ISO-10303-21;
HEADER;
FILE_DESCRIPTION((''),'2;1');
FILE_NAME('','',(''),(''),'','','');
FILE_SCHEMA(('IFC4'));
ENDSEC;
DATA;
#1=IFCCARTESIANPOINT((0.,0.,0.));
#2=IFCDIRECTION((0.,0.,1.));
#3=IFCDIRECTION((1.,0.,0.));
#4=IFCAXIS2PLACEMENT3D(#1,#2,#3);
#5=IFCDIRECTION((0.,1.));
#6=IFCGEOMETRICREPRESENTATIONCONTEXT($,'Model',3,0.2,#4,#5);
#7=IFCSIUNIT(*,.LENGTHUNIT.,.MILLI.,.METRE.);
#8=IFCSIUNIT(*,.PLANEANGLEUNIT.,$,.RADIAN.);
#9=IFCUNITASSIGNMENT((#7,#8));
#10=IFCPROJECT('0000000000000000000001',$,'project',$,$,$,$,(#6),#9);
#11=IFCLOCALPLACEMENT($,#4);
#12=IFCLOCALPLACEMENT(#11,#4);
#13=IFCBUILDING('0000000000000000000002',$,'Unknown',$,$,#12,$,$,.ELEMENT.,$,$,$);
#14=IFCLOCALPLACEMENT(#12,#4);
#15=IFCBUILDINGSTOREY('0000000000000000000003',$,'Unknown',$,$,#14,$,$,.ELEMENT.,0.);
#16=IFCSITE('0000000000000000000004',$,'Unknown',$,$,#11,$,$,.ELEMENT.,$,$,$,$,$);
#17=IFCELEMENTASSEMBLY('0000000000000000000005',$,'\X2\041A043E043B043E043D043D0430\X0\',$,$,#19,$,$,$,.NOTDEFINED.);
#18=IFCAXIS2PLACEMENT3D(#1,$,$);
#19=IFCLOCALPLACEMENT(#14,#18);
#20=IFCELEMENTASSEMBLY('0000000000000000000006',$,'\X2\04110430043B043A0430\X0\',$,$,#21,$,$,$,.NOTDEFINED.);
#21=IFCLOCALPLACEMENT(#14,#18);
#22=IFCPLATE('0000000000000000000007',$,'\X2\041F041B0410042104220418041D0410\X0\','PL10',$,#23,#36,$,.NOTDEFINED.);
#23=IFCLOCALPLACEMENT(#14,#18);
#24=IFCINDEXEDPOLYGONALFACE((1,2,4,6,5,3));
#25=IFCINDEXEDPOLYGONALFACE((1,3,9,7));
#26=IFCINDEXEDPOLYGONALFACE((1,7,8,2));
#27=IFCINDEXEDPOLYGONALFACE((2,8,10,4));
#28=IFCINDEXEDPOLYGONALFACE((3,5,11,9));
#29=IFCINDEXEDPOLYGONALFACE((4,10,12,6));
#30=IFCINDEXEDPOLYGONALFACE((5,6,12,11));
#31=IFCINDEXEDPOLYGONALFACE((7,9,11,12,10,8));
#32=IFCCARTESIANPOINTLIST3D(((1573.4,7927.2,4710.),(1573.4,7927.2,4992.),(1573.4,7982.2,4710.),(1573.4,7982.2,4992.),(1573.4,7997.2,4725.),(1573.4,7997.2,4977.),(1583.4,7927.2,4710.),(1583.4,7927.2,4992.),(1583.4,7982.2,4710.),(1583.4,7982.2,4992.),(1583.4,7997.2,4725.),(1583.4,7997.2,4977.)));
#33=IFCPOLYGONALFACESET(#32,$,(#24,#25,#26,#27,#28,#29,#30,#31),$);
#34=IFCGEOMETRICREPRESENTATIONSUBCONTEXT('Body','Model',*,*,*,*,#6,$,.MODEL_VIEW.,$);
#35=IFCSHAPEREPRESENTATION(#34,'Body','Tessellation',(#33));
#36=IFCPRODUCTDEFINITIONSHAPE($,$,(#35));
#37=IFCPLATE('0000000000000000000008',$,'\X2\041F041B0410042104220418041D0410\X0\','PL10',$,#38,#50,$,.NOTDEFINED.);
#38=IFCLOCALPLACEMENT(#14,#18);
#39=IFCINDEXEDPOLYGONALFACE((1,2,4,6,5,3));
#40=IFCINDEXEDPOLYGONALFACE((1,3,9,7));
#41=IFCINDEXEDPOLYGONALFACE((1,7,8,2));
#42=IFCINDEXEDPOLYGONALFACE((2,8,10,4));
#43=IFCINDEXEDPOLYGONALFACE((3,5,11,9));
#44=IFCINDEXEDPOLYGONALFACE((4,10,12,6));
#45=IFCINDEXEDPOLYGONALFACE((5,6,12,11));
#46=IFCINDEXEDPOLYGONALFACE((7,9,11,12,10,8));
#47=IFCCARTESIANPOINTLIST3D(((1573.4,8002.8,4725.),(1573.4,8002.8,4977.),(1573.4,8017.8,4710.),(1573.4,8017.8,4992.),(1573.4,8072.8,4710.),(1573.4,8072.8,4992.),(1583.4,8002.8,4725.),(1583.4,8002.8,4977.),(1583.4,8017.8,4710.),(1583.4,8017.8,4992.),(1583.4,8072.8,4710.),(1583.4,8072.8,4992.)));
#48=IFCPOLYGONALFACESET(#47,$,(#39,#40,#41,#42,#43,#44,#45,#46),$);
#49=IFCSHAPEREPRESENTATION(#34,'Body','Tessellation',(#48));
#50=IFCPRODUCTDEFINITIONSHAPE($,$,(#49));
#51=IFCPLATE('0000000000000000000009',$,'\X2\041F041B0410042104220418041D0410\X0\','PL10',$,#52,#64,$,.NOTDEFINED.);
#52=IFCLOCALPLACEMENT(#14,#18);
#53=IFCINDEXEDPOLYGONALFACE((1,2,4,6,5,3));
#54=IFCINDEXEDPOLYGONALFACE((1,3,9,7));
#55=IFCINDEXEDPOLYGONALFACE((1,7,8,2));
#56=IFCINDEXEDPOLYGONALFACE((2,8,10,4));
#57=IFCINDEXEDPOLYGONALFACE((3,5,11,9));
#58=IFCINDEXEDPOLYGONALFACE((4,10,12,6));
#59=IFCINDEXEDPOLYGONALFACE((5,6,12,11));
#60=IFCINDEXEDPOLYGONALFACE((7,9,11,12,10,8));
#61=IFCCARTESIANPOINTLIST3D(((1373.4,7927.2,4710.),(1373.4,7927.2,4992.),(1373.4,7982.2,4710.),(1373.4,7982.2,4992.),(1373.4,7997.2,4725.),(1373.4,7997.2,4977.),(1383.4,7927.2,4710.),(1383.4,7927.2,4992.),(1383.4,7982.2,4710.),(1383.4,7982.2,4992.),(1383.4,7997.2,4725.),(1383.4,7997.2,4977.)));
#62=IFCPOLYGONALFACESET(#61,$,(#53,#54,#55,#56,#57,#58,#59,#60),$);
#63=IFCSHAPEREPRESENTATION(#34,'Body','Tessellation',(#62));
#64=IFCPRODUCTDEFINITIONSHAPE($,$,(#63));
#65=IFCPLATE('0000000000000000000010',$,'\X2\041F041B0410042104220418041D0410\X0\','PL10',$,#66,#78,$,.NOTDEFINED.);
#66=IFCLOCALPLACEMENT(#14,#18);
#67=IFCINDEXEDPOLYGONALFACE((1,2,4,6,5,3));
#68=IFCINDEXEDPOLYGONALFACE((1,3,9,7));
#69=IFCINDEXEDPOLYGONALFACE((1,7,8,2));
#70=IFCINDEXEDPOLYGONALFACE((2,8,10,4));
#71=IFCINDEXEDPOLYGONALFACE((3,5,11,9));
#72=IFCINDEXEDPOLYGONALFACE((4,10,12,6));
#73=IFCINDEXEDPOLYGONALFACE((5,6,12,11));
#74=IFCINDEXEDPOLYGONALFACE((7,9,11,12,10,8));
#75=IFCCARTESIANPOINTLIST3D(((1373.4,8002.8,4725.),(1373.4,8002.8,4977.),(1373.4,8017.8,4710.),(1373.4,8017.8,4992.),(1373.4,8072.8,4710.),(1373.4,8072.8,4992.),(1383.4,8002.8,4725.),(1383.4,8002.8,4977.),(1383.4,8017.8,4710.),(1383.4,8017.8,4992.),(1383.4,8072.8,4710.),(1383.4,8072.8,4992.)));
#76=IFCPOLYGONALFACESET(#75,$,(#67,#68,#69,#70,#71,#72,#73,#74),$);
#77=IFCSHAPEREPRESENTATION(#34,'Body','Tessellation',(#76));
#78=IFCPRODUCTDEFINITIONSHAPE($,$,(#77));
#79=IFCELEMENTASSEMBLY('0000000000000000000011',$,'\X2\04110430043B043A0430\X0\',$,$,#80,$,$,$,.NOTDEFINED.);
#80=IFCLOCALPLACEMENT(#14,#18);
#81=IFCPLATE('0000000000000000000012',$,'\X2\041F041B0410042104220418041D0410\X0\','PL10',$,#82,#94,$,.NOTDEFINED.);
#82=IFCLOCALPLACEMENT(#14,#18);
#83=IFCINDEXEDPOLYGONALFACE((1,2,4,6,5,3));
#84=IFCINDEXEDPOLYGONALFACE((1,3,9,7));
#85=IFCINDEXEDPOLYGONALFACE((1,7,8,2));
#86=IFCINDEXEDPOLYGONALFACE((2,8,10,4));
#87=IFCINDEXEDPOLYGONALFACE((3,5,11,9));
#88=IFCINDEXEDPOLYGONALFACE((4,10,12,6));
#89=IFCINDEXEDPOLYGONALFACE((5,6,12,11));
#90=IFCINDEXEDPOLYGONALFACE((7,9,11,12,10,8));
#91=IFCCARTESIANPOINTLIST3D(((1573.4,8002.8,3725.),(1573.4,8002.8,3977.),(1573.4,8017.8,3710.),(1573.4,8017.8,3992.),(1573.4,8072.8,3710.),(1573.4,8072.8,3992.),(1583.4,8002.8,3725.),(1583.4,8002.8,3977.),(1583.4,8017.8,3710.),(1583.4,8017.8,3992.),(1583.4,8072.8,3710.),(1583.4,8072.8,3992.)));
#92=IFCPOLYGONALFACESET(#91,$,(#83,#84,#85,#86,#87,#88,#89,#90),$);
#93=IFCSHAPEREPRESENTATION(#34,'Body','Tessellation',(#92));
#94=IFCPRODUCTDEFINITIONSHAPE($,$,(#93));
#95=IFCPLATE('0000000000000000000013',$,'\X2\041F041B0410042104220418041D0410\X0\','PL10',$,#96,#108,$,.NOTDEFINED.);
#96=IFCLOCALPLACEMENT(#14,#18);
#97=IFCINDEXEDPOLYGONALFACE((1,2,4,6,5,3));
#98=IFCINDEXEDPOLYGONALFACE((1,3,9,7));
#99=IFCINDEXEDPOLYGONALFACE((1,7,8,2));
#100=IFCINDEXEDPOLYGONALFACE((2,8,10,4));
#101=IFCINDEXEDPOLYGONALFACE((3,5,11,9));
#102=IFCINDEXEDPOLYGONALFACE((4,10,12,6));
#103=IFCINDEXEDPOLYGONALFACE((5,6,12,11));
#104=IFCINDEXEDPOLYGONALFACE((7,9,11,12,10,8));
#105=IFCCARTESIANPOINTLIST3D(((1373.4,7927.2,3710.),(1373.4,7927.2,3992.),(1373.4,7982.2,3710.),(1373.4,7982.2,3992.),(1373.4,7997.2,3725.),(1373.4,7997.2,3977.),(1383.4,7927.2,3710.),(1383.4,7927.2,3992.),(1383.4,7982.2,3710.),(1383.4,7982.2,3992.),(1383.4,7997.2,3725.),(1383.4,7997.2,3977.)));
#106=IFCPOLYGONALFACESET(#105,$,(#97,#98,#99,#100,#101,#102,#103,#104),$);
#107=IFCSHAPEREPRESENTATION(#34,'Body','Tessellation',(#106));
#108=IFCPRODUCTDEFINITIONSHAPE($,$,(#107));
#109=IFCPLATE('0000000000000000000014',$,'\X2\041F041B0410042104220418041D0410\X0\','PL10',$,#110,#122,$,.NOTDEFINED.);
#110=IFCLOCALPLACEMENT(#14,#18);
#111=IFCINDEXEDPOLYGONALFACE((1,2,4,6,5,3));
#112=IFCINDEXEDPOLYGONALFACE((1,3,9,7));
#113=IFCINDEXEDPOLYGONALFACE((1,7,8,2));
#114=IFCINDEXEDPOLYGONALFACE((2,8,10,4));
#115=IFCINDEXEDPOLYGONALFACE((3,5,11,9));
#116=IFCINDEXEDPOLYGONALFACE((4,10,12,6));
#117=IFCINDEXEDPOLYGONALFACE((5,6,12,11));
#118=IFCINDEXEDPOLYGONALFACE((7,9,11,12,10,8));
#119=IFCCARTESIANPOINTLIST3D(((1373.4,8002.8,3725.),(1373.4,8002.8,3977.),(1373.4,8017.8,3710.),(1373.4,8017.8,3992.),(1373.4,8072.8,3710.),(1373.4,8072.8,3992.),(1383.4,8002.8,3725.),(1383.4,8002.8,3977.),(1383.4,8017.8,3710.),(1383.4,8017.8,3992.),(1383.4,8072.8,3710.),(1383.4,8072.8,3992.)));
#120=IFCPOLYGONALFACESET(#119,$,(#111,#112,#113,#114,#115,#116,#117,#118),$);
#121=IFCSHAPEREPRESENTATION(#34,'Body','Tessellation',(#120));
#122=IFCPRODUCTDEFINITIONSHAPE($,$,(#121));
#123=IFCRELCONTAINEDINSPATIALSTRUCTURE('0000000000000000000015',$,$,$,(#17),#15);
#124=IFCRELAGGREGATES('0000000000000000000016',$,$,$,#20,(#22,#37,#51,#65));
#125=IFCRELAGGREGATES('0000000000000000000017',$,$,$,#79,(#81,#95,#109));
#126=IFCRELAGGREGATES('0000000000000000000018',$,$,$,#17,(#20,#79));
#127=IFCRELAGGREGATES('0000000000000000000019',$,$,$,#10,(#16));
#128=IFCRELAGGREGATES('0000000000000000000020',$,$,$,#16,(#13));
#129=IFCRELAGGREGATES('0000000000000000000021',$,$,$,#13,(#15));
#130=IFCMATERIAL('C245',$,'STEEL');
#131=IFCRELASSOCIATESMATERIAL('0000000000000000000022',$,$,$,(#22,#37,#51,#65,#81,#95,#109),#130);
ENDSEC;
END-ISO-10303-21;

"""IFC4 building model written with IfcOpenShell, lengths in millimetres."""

from ifc_helpers import new_model, si_unit, direction, frame, origin_with_axes, place, context, subcontext, project, spatial, line, indexed_curve, outline, extrude, material, element, aggregate, save


model = new_model("IFC4")

# Units and contexts
model_context = context("Model", 3, precision=0.2, world=origin_with_axes(), true_north=direction((0.0, 1.0)))
body_context = subcontext(model_context, "Body", "Model", "MODEL_VIEW")
ifc_project = project(units=[si_unit("LENGTHUNIT", "METRE", prefix="MILLI"), si_unit("PLANEANGLEUNIT", "RADIAN")], contexts=[model_context])

# Site, building, storey
site_placement = place(None, origin_with_axes())
site = spatial("IfcSite", under=ifc_project, at=site_placement, Name="Unknown", CompositionType="ELEMENT")
building_placement = place(site_placement, origin_with_axes())
building = spatial("IfcBuilding", under=site, at=building_placement, Name="Unknown", CompositionType="ELEMENT")
storey_placement = place(building_placement, origin_with_axes())
storey = spatial("IfcBuildingStorey", under=building, at=storey_placement, Name="Unknown", CompositionType="ELEMENT", Elevation=0.0)

# Element assemblies, plates
ifc_material_1 = material(Name="C245", Category="STEEL")
assembly_1_placement = place(storey_placement, frame((0.0, 8000.0, 0.0), z_axis=(0.0, -1.0, 0.0), x_axis=(0.0, 0.0, 1.0)))
assembly_1 = element("IfcElementAssembly", 1, at=assembly_1_placement, inside=storey, Name="Колонна", PredefinedType="NOTDEFINED")
assembly_2_placement = place(assembly_1_placement, frame((4851.0, 0.0, 0.0), z_axis=(0.0, 0.0, 1.0), x_axis=(0.0, -1.0, 0.0)))
assembly_2 = element("IfcElementAssembly", 2, at=assembly_2_placement, Name="Балка", PredefinedType="NOTDEFINED")
plate_1_placement = place(assembly_2_placement, frame((1578.4, -141.0, 72.8), z_axis=(1.0, 0.0, 0.0), x_axis=(0.0, 0.0, -1.0)))
plate_1 = element("IfcPlate", 3, at=plate_1_placement, material=ifc_material_1, Name="ПЛАСТИНА", Description="PL10", PredefinedType="NOTDEFINED", context=body_context, shape_type="SolidModel", body=[
    extrude(outline(indexed_curve([(0.0, 0.0), (55.0, 0.0), (70.0, 15.0), (70.0, 267.0), (55.0, 282.0), (0.0, 282.0)], segments=[line(1, 2, 3, 4, 5, 6, 1)])), frame((0.0, 0.0, 5.0), z_axis=(0.0, 0.0, 1.0), x_axis=(1.0, 0.0, 0.0)), (0.0, 0.0, -1.0), 10.0),
])
plate_2_placement = place(assembly_2_placement, frame((1578.4, -141.0, -2.8), z_axis=(1.0, 0.0, 0.0), x_axis=(0.0, 0.0, -1.0)))
plate_2 = element("IfcPlate", 4, at=plate_2_placement, material=ifc_material_1, Name="ПЛАСТИНА", Description="PL10", PredefinedType="NOTDEFINED", context=body_context, shape_type="SolidModel", body=[
    extrude(outline(indexed_curve([(0.0, 15.0), (15.0, 0.0), (70.0, 0.0), (70.0, 282.0), (15.0, 282.0), (0.0, 267.0)], segments=[line(1, 2, 3, 4, 5, 6, 1)])), frame((0.0, 0.0, 5.0), z_axis=(0.0, 0.0, 1.0), x_axis=(1.0, 0.0, 0.0)), (0.0, 0.0, -1.0), 10.0),
])
plate_3_placement = place(assembly_2_placement, frame((1378.4, -141.0, 72.8), z_axis=(1.0, 0.0, 0.0), x_axis=(0.0, 0.0, -1.0)))
plate_3 = element("IfcPlate", 5, at=plate_3_placement, material=ifc_material_1, Name="ПЛАСТИНА", Description="PL10", PredefinedType="NOTDEFINED", context=body_context, shape_type="SolidModel", body=[
    extrude(outline(indexed_curve([(0.0, 0.0), (55.0, 0.0), (70.0, 15.0), (70.0, 267.0), (55.0, 282.0), (0.0, 282.0)], segments=[line(1, 2, 3, 4, 5, 6, 1)])), frame((0.0, 0.0, 5.0), z_axis=(0.0, 0.0, 1.0), x_axis=(1.0, 0.0, 0.0)), (0.0, 0.0, -1.0), 10.0),
])
plate_4_placement = place(assembly_2_placement, frame((1378.4, -141.0, -2.8), z_axis=(1.0, 0.0, 0.0), x_axis=(0.0, 0.0, -1.0)))
plate_4 = element("IfcPlate", 6, at=plate_4_placement, material=ifc_material_1, Name="ПЛАСТИНА", Description="PL10", PredefinedType="NOTDEFINED", context=body_context, shape_type="SolidModel", body=[
    extrude(outline(indexed_curve([(0.0, 15.0), (15.0, 0.0), (70.0, 0.0), (70.0, 282.0), (15.0, 282.0), (0.0, 267.0)], segments=[line(1, 2, 3, 4, 5, 6, 1)])), frame((0.0, 0.0, 5.0), z_axis=(0.0, 0.0, 1.0), x_axis=(1.0, 0.0, 0.0)), (0.0, 0.0, -1.0), 10.0),
])
aggregate(assembly_2, [plate_1, plate_2, plate_3, plate_4])
assembly_3_placement = place(assembly_1_placement, frame((3851.0, 0.0, 0.0), z_axis=(0.0, 0.0, 1.0), x_axis=(0.0, -1.0, 0.0)))
assembly_3 = element("IfcElementAssembly", 7, at=assembly_3_placement, Name="Балка", PredefinedType="NOTDEFINED")
plate_5_placement = place(assembly_3_placement, frame((1578.4, -141.0, -2.8), z_axis=(1.0, 0.0, 0.0), x_axis=(0.0, 0.0, -1.0)))
plate_5 = element("IfcPlate", 8, at=plate_5_placement, material=ifc_material_1, Name="ПЛАСТИНА", Description="PL10", PredefinedType="NOTDEFINED", context=body_context, shape_type="SolidModel", body=[
    extrude(outline(indexed_curve([(0.0, 15.0), (15.0, 0.0), (70.0, 0.0), (70.0, 282.0), (15.0, 282.0), (0.0, 267.0)], segments=[line(1, 2, 3, 4, 5, 6, 1)])), frame((0.0, 0.0, 5.0), z_axis=(0.0, 0.0, 1.0), x_axis=(1.0, 0.0, 0.0)), (0.0, 0.0, -1.0), 10.0),
])
plate_6_placement = place(assembly_3_placement, frame((1378.4, -141.0, 72.8), z_axis=(1.0, 0.0, 0.0), x_axis=(0.0, 0.0, -1.0)))
plate_6 = element("IfcPlate", 9, at=plate_6_placement, material=ifc_material_1, Name="ПЛАСТИНА", Description="PL10", PredefinedType="NOTDEFINED", context=body_context, shape_type="SolidModel", body=[
    extrude(outline(indexed_curve([(0.0, 0.0), (55.0, 0.0), (70.0, 15.0), (70.0, 267.0), (55.0, 282.0), (0.0, 282.0)], segments=[line(1, 2, 3, 4, 5, 6, 1)])), frame((0.0, 0.0, 5.0), z_axis=(0.0, 0.0, 1.0), x_axis=(1.0, 0.0, 0.0)), (0.0, 0.0, -1.0), 10.0),
])
plate_7_placement = place(assembly_3_placement, frame((1378.4, -141.0, -2.8), z_axis=(1.0, 0.0, 0.0), x_axis=(0.0, 0.0, -1.0)))
plate_7 = element("IfcPlate", 10, at=plate_7_placement, material=ifc_material_1, Name="ПЛАСТИНА", Description="PL10", PredefinedType="NOTDEFINED", context=body_context, shape_type="SolidModel", body=[
    extrude(outline(indexed_curve([(0.0, 15.0), (15.0, 0.0), (70.0, 0.0), (70.0, 282.0), (15.0, 282.0), (0.0, 267.0)], segments=[line(1, 2, 3, 4, 5, 6, 1)])), frame((0.0, 0.0, 5.0), z_axis=(0.0, 0.0, 1.0), x_axis=(1.0, 0.0, 0.0)), (0.0, 0.0, -1.0), 10.0),
])
aggregate(assembly_3, [plate_5, plate_6, plate_7])

aggregate(assembly_1, [assembly_2, assembly_3])

save(model, "model.ifc")
